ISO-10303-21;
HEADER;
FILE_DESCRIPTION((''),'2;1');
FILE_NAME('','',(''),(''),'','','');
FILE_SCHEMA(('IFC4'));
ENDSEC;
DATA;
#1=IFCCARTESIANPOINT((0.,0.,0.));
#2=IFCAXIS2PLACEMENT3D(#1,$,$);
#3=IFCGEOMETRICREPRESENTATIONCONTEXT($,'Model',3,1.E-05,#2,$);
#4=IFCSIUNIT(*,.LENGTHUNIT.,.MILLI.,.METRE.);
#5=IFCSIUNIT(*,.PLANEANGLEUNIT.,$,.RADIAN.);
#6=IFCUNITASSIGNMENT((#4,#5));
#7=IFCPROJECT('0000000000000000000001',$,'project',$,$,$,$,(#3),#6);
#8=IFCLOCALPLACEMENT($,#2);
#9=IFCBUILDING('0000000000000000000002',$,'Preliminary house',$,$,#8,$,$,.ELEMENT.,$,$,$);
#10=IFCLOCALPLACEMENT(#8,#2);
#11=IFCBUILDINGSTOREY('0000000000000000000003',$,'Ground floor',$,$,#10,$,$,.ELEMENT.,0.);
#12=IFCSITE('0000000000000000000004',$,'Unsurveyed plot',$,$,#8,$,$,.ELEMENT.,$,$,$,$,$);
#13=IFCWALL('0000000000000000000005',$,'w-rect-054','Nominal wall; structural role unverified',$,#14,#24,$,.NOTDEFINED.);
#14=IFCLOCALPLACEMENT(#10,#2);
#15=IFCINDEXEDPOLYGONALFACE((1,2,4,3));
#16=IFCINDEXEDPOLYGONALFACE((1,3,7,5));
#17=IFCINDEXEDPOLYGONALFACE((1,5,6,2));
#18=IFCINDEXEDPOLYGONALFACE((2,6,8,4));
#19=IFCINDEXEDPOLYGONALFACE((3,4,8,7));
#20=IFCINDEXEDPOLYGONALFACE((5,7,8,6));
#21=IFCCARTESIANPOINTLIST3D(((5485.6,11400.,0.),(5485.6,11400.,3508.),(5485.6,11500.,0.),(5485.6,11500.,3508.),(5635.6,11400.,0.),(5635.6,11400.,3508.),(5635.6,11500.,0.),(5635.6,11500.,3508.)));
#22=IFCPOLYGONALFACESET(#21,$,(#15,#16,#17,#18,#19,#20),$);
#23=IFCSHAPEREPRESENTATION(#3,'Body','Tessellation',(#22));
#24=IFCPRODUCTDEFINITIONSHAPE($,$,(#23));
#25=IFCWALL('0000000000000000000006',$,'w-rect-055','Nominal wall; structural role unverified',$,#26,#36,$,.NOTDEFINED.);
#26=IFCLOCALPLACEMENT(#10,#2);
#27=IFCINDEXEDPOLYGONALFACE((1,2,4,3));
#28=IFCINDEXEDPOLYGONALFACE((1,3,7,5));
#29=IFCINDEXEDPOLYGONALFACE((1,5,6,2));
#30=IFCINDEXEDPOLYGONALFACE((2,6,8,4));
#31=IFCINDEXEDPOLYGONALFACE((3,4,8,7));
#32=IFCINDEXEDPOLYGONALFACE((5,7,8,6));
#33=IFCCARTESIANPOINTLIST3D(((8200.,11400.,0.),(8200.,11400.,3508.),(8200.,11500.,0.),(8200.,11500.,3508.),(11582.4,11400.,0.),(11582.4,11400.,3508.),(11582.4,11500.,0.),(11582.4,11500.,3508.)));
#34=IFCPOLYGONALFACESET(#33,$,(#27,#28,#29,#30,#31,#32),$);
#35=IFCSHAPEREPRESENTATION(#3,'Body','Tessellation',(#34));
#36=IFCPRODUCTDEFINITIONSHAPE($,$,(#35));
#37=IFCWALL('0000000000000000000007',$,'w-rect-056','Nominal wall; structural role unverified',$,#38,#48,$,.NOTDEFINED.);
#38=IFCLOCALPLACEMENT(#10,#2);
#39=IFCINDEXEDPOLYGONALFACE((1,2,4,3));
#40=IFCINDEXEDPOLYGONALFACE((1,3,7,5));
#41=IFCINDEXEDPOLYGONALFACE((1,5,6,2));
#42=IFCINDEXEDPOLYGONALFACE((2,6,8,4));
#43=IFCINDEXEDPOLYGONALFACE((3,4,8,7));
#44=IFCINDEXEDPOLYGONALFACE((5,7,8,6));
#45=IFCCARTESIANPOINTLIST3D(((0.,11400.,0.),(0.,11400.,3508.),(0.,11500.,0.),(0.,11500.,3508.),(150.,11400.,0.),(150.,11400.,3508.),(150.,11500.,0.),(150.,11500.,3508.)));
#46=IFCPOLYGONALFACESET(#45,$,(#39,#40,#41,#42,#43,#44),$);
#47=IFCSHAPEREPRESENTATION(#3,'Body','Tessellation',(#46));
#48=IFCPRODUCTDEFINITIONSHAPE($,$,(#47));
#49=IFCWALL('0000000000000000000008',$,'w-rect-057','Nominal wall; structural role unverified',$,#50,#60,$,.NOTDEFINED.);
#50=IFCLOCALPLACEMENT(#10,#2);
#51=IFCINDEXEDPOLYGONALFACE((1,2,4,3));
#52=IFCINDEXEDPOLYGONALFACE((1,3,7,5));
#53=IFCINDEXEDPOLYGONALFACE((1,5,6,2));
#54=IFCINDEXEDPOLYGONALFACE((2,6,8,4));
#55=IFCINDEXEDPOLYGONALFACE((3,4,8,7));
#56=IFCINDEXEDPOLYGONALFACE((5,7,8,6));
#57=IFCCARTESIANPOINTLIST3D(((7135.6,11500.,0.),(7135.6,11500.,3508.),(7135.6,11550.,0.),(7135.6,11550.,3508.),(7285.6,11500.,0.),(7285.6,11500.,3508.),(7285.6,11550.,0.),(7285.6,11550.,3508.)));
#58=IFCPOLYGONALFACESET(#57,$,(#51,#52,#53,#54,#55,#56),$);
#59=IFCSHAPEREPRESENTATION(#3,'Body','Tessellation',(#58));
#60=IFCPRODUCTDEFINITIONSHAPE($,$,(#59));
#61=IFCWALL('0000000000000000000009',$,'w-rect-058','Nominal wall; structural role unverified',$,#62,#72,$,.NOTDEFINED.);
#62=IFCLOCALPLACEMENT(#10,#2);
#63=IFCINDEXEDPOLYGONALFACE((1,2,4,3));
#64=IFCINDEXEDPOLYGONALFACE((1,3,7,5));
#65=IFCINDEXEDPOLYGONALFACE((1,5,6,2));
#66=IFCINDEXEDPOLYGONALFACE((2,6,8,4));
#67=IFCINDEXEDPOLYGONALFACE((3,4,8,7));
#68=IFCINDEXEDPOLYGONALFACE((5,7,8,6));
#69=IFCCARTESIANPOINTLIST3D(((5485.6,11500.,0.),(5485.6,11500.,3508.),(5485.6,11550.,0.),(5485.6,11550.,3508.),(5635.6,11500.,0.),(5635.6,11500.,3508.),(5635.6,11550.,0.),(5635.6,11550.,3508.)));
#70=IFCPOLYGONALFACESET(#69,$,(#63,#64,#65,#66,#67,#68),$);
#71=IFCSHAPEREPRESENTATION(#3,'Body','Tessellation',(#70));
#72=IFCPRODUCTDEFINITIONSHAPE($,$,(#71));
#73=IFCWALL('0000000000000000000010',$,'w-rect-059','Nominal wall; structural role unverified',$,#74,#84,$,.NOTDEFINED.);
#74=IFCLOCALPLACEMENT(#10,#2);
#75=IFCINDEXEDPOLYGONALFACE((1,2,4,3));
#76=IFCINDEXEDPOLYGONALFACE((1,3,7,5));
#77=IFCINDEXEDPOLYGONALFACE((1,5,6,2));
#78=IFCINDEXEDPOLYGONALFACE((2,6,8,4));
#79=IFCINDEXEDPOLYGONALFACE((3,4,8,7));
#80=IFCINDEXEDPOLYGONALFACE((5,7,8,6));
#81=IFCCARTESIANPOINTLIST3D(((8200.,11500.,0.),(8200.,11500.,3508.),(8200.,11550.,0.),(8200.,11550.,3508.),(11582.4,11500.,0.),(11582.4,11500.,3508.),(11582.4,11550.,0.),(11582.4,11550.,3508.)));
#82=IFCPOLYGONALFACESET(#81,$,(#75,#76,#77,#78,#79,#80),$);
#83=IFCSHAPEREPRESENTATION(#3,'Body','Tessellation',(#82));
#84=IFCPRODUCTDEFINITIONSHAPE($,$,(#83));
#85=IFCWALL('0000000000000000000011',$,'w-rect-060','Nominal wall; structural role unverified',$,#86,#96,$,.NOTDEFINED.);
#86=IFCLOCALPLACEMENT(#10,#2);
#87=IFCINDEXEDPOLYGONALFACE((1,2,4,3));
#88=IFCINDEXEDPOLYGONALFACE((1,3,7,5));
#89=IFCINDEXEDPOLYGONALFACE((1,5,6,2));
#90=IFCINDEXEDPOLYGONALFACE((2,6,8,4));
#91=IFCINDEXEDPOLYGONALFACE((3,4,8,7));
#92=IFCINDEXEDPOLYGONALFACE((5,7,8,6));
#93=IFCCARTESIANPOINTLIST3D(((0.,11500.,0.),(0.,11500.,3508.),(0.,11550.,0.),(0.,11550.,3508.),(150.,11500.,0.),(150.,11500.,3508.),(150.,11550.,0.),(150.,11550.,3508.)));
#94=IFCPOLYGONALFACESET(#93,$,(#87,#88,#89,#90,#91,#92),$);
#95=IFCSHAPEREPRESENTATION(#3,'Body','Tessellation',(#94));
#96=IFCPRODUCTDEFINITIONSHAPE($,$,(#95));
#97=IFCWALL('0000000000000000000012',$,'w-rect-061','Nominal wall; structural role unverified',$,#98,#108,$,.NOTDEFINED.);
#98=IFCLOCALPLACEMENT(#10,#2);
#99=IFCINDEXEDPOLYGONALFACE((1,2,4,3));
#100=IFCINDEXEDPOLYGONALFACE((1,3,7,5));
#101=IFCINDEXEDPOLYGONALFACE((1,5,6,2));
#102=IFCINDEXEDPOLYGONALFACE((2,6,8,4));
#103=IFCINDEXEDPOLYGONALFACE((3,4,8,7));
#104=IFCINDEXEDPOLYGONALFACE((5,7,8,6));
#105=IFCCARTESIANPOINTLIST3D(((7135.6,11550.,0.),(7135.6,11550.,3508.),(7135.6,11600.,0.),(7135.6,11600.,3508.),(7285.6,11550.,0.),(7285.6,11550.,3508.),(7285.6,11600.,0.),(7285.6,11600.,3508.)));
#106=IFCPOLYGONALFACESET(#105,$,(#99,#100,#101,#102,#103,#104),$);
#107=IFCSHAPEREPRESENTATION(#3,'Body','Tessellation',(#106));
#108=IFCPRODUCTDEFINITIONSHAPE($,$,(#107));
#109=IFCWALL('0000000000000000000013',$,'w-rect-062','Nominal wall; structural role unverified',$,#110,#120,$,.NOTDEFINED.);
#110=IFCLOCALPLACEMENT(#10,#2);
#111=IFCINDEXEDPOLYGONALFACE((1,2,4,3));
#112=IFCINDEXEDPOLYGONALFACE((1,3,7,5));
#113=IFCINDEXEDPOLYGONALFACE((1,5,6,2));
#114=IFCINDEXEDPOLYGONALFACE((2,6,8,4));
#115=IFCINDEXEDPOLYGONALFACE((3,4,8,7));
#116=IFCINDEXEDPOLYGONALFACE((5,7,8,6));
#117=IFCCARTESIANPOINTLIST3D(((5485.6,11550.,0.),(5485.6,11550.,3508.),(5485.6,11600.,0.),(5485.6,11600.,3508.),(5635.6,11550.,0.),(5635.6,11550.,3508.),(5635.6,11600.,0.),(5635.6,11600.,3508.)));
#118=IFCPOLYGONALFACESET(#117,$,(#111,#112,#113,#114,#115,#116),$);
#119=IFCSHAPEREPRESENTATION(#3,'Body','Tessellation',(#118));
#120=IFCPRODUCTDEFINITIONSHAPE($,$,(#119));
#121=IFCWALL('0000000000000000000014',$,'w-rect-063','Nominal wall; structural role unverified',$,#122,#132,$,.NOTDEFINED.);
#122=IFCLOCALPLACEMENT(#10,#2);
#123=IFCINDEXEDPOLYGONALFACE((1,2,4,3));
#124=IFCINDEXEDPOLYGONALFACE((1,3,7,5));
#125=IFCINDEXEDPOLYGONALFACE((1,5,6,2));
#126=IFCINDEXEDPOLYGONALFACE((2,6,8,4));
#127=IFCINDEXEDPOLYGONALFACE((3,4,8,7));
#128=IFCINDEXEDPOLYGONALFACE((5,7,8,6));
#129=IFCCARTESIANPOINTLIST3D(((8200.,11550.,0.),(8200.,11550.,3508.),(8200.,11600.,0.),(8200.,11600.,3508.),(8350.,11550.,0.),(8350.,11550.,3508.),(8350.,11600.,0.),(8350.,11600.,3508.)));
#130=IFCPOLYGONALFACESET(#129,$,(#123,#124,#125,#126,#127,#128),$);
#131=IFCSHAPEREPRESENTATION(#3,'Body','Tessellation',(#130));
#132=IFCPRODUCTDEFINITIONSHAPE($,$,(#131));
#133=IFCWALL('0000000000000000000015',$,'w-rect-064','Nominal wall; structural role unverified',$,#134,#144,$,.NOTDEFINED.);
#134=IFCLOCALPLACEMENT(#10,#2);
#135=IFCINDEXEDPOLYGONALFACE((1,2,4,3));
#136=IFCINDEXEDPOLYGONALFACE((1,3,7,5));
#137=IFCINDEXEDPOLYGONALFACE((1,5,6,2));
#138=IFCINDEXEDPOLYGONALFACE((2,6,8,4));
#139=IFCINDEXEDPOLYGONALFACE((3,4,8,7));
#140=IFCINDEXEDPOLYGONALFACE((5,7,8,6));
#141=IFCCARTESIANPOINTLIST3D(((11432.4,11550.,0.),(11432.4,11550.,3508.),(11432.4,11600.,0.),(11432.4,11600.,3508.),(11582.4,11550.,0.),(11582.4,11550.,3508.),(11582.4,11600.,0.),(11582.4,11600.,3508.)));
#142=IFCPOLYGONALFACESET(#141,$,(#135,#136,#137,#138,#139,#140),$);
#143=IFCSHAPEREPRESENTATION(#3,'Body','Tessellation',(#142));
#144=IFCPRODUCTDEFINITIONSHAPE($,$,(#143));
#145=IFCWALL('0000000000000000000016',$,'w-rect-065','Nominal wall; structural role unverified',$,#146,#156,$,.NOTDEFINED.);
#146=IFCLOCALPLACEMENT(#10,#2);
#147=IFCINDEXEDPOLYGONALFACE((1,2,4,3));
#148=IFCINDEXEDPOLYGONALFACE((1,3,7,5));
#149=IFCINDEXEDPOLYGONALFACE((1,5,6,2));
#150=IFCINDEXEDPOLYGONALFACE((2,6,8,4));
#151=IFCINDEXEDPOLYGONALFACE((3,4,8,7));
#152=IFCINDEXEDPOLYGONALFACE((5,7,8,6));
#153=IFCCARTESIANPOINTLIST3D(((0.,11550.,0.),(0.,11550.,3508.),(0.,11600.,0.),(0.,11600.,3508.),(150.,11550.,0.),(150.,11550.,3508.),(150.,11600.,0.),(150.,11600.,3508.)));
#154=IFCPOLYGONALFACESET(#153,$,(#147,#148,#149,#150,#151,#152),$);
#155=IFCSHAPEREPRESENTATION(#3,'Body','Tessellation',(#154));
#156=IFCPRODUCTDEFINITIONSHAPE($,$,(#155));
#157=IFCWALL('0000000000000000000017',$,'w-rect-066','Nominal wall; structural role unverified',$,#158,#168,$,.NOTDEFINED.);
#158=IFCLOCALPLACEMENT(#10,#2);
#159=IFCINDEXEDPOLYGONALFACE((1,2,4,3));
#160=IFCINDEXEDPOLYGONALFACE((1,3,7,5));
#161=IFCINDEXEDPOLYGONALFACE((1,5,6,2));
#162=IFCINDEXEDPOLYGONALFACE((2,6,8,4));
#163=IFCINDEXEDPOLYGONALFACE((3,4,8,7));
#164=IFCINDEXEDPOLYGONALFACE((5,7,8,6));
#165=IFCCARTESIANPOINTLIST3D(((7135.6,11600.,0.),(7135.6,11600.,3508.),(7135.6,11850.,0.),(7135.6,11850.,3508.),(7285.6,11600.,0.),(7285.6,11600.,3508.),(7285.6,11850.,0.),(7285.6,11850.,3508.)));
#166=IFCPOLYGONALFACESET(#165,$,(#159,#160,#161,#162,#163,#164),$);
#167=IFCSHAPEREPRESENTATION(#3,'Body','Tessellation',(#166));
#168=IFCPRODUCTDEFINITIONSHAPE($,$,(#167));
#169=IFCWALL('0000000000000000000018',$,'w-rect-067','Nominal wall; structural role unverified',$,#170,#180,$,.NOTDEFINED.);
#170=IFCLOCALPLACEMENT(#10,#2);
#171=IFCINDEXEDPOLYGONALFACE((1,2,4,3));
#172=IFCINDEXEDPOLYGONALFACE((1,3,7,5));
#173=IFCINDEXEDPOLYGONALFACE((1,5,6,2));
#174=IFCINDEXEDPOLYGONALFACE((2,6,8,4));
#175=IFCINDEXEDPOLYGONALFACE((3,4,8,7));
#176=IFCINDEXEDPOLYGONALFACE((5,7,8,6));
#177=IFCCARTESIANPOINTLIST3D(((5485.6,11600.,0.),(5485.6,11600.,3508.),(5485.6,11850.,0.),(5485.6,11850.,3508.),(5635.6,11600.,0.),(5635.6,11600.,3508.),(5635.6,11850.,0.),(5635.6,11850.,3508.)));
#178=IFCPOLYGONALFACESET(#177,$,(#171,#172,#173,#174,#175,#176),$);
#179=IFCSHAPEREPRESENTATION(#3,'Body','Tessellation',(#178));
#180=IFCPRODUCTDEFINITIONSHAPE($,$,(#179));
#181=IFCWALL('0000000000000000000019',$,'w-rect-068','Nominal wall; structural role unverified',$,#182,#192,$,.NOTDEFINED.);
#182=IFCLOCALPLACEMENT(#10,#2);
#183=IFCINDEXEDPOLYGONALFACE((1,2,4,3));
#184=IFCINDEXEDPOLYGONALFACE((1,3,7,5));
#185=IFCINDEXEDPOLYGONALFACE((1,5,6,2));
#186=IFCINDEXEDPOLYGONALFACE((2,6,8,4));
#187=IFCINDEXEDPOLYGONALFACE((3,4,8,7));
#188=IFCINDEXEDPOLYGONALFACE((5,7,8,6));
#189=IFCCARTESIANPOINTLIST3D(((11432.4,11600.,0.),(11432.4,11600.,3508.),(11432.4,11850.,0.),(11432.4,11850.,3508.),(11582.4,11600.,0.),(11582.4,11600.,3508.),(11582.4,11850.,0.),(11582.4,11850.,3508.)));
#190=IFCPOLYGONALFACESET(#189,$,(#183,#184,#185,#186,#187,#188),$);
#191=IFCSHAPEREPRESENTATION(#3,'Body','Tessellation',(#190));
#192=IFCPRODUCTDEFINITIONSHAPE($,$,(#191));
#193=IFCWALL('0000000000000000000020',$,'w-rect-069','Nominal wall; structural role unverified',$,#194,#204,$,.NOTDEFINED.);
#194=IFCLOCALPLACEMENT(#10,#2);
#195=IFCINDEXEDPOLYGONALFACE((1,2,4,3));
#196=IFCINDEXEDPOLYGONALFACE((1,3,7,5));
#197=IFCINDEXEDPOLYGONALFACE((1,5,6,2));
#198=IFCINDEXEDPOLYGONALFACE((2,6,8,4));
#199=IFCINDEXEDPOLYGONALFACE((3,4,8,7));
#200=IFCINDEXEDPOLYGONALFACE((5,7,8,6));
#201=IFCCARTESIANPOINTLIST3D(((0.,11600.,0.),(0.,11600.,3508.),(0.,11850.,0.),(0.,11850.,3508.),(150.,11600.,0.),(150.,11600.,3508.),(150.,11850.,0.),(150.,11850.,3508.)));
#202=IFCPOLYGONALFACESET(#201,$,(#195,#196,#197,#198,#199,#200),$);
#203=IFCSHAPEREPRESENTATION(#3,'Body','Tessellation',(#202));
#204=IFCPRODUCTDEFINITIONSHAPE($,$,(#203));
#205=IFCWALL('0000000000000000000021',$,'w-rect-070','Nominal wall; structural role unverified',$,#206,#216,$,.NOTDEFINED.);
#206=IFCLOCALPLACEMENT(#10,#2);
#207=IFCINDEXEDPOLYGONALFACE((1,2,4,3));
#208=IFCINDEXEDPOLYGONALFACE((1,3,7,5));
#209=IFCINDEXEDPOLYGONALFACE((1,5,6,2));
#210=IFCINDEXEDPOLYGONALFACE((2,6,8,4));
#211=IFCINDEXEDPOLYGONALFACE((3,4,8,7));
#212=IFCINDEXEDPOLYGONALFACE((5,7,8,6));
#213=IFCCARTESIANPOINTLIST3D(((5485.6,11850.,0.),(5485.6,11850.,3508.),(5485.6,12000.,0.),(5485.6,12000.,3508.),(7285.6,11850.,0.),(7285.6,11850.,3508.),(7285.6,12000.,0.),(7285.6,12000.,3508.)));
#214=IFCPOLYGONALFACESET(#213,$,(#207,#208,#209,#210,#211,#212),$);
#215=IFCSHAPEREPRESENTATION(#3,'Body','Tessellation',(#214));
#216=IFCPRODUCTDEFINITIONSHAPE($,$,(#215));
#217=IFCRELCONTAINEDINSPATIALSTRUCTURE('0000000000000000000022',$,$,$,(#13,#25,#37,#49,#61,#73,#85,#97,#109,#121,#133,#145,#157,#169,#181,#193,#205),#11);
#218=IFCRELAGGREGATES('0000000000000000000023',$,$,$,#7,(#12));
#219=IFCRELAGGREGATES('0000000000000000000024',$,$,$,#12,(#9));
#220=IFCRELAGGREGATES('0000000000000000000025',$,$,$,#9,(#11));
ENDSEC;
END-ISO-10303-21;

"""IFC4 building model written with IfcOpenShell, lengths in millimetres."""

from ifc_helpers import new_model, si_unit, origin, place, context, project, spatial, polyline, outline, extrude, element, save


model = new_model("IFC4")

# Units and contexts
model_context = context("Model", 3, precision=1e-05, world=origin())
ifc_project = project(units=[si_unit("LENGTHUNIT", "METRE", prefix="MILLI"), si_unit("PLANEANGLEUNIT", "RADIAN")], contexts=[model_context])

# Site, building, storey
placement_1 = place(None, origin())
site = spatial("IfcSite", under=ifc_project, at=placement_1, Name="Unsurveyed plot", CompositionType="ELEMENT")
building = spatial("IfcBuilding", under=site, at=placement_1, Name="Preliminary house", CompositionType="ELEMENT")
placement_2 = place(placement_1, origin())
storey = spatial("IfcBuildingStorey", under=building, at=placement_2, Name="Ground floor", CompositionType="ELEMENT", Elevation=0.0)

# Walls
element("IfcWall", 1, at=placement_2, inside=storey, Name="w-rect-054", Description="Nominal wall; structural role unverified", PredefinedType="NOTDEFINED", context=model_context, shape_type="SweptSolid", body=[
    extrude(outline(polyline([(5485.6, 11400.0), (5635.6, 11400.0), (5635.6, 11500.0), (5485.6, 11500.0), (5485.6, 11400.0)])), origin(), (0.0, 0.0, 1.0), 3508.0),
])
element("IfcWall", 2, at=placement_2, inside=storey, Name="w-rect-055", Description="Nominal wall; structural role unverified", PredefinedType="NOTDEFINED", context=model_context, shape_type="SweptSolid", body=[
    extrude(outline(polyline([(8200.0, 11400.0), (11582.4, 11400.0), (11582.4, 11500.0), (8200.0, 11500.0), (8200.0, 11400.0)])), origin(), (0.0, 0.0, 1.0), 3508.0),
])
element("IfcWall", 3, at=placement_2, inside=storey, Name="w-rect-056", Description="Nominal wall; structural role unverified", PredefinedType="NOTDEFINED", context=model_context, shape_type="SweptSolid", body=[
    extrude(outline(polyline([(0.0, 11400.0), (150.0, 11400.0), (150.0, 11500.0), (0.0, 11500.0), (0.0, 11400.0)])), origin(), (0.0, 0.0, 1.0), 3508.0),
])
element("IfcWall", 4, at=placement_2, inside=storey, Name="w-rect-057", Description="Nominal wall; structural role unverified", PredefinedType="NOTDEFINED", context=model_context, shape_type="SweptSolid", body=[
    extrude(outline(polyline([(7135.6, 11500.0), (7285.6, 11500.0), (7285.6, 11550.0), (7135.6, 11550.0), (7135.6, 11500.0)])), origin(), (0.0, 0.0, 1.0), 3508.0),
])
element("IfcWall", 5, at=placement_2, inside=storey, Name="w-rect-058", Description="Nominal wall; structural role unverified", PredefinedType="NOTDEFINED", context=model_context, shape_type="SweptSolid", body=[
    extrude(outline(polyline([(5485.6, 11500.0), (5635.6, 11500.0), (5635.6, 11550.0), (5485.6, 11550.0), (5485.6, 11500.0)])), origin(), (0.0, 0.0, 1.0), 3508.0),
])
element("IfcWall", 6, at=placement_2, inside=storey, Name="w-rect-059", Description="Nominal wall; structural role unverified", PredefinedType="NOTDEFINED", context=model_context, shape_type="SweptSolid", body=[
    extrude(outline(polyline([(8200.0, 11500.0), (11582.4, 11500.0), (11582.4, 11550.0), (8200.0, 11550.0), (8200.0, 11500.0)])), origin(), (0.0, 0.0, 1.0), 3508.0),
])
element("IfcWall", 7, at=placement_2, inside=storey, Name="w-rect-060", Description="Nominal wall; structural role unverified", PredefinedType="NOTDEFINED", context=model_context, shape_type="SweptSolid", body=[
    extrude(outline(polyline([(0.0, 11500.0), (150.0, 11500.0), (150.0, 11550.0), (0.0, 11550.0), (0.0, 11500.0)])), origin(), (0.0, 0.0, 1.0), 3508.0),
])
element("IfcWall", 8, at=placement_2, inside=storey, Name="w-rect-061", Description="Nominal wall; structural role unverified", PredefinedType="NOTDEFINED", context=model_context, shape_type="SweptSolid", body=[
    extrude(outline(polyline([(7135.6, 11550.0), (7285.6, 11550.0), (7285.6, 11600.0), (7135.6, 11600.0), (7135.6, 11550.0)])), origin(), (0.0, 0.0, 1.0), 3508.0),
])
element("IfcWall", 9, at=placement_2, inside=storey, Name="w-rect-062", Description="Nominal wall; structural role unverified", PredefinedType="NOTDEFINED", context=model_context, shape_type="SweptSolid", body=[
    extrude(outline(polyline([(5485.6, 11550.0), (5635.6, 11550.0), (5635.6, 11600.0), (5485.6, 11600.0), (5485.6, 11550.0)])), origin(), (0.0, 0.0, 1.0), 3508.0),
])
element("IfcWall", 10, at=placement_2, inside=storey, Name="w-rect-063", Description="Nominal wall; structural role unverified", PredefinedType="NOTDEFINED", context=model_context, shape_type="SweptSolid", body=[
    extrude(outline(polyline([(8200.0, 11550.0), (8350.0, 11550.0), (8350.0, 11600.0), (8200.0, 11600.0), (8200.0, 11550.0)])), origin(), (0.0, 0.0, 1.0), 3508.0),
])
element("IfcWall", 11, at=placement_2, inside=storey, Name="w-rect-064", Description="Nominal wall; structural role unverified", PredefinedType="NOTDEFINED", context=model_context, shape_type="SweptSolid", body=[
    extrude(outline(polyline([(11432.4, 11550.0), (11582.4, 11550.0), (11582.4, 11600.0), (11432.4, 11600.0), (11432.4, 11550.0)])), origin(), (0.0, 0.0, 1.0), 3508.0),
])
element("IfcWall", 12, at=placement_2, inside=storey, Name="w-rect-065", Description="Nominal wall; structural role unverified", PredefinedType="NOTDEFINED", context=model_context, shape_type="SweptSolid", body=[
    extrude(outline(polyline([(0.0, 11550.0), (150.0, 11550.0), (150.0, 11600.0), (0.0, 11600.0), (0.0, 11550.0)])), origin(), (0.0, 0.0, 1.0), 3508.0),
])
element("IfcWall", 13, at=placement_2, inside=storey, Name="w-rect-066", Description="Nominal wall; structural role unverified", PredefinedType="NOTDEFINED", context=model_context, shape_type="SweptSolid", body=[
    extrude(outline(polyline([(7135.6, 11600.0), (7285.6, 11600.0), (7285.6, 11850.0), (7135.6, 11850.0), (7135.6, 11600.0)])), origin(), (0.0, 0.0, 1.0), 3508.0),
])
element("IfcWall", 14, at=placement_2, inside=storey, Name="w-rect-067", Description="Nominal wall; structural role unverified", PredefinedType="NOTDEFINED", context=model_context, shape_type="SweptSolid", body=[
    extrude(outline(polyline([(5485.6, 11600.0), (5635.6, 11600.0), (5635.6, 11850.0), (5485.6, 11850.0), (5485.6, 11600.0)])), origin(), (0.0, 0.0, 1.0), 3508.0),
])
element("IfcWall", 15, at=placement_2, inside=storey, Name="w-rect-068", Description="Nominal wall; structural role unverified", PredefinedType="NOTDEFINED", context=model_context, shape_type="SweptSolid", body=[
    extrude(outline(polyline([(11432.4, 11600.0), (11582.4, 11600.0), (11582.4, 11850.0), (11432.4, 11850.0), (11432.4, 11600.0)])), origin(), (0.0, 0.0, 1.0), 3508.0),
])
element("IfcWall", 16, at=placement_2, inside=storey, Name="w-rect-069", Description="Nominal wall; structural role unverified", PredefinedType="NOTDEFINED", context=model_context, shape_type="SweptSolid", body=[
    extrude(outline(polyline([(0.0, 11600.0), (150.0, 11600.0), (150.0, 11850.0), (0.0, 11850.0), (0.0, 11600.0)])), origin(), (0.0, 0.0, 1.0), 3508.0),
])
element("IfcWall", 17, at=placement_2, inside=storey, Name="w-rect-070", Description="Nominal wall; structural role unverified", PredefinedType="NOTDEFINED", context=model_context, shape_type="SweptSolid", body=[
    extrude(outline(polyline([(5485.6, 11850.0), (7285.6, 11850.0), (7285.6, 12000.0), (5485.6, 12000.0), (5485.6, 11850.0)])), origin(), (0.0, 0.0, 1.0), 3508.0),
])

save(model, "model.ifc")
